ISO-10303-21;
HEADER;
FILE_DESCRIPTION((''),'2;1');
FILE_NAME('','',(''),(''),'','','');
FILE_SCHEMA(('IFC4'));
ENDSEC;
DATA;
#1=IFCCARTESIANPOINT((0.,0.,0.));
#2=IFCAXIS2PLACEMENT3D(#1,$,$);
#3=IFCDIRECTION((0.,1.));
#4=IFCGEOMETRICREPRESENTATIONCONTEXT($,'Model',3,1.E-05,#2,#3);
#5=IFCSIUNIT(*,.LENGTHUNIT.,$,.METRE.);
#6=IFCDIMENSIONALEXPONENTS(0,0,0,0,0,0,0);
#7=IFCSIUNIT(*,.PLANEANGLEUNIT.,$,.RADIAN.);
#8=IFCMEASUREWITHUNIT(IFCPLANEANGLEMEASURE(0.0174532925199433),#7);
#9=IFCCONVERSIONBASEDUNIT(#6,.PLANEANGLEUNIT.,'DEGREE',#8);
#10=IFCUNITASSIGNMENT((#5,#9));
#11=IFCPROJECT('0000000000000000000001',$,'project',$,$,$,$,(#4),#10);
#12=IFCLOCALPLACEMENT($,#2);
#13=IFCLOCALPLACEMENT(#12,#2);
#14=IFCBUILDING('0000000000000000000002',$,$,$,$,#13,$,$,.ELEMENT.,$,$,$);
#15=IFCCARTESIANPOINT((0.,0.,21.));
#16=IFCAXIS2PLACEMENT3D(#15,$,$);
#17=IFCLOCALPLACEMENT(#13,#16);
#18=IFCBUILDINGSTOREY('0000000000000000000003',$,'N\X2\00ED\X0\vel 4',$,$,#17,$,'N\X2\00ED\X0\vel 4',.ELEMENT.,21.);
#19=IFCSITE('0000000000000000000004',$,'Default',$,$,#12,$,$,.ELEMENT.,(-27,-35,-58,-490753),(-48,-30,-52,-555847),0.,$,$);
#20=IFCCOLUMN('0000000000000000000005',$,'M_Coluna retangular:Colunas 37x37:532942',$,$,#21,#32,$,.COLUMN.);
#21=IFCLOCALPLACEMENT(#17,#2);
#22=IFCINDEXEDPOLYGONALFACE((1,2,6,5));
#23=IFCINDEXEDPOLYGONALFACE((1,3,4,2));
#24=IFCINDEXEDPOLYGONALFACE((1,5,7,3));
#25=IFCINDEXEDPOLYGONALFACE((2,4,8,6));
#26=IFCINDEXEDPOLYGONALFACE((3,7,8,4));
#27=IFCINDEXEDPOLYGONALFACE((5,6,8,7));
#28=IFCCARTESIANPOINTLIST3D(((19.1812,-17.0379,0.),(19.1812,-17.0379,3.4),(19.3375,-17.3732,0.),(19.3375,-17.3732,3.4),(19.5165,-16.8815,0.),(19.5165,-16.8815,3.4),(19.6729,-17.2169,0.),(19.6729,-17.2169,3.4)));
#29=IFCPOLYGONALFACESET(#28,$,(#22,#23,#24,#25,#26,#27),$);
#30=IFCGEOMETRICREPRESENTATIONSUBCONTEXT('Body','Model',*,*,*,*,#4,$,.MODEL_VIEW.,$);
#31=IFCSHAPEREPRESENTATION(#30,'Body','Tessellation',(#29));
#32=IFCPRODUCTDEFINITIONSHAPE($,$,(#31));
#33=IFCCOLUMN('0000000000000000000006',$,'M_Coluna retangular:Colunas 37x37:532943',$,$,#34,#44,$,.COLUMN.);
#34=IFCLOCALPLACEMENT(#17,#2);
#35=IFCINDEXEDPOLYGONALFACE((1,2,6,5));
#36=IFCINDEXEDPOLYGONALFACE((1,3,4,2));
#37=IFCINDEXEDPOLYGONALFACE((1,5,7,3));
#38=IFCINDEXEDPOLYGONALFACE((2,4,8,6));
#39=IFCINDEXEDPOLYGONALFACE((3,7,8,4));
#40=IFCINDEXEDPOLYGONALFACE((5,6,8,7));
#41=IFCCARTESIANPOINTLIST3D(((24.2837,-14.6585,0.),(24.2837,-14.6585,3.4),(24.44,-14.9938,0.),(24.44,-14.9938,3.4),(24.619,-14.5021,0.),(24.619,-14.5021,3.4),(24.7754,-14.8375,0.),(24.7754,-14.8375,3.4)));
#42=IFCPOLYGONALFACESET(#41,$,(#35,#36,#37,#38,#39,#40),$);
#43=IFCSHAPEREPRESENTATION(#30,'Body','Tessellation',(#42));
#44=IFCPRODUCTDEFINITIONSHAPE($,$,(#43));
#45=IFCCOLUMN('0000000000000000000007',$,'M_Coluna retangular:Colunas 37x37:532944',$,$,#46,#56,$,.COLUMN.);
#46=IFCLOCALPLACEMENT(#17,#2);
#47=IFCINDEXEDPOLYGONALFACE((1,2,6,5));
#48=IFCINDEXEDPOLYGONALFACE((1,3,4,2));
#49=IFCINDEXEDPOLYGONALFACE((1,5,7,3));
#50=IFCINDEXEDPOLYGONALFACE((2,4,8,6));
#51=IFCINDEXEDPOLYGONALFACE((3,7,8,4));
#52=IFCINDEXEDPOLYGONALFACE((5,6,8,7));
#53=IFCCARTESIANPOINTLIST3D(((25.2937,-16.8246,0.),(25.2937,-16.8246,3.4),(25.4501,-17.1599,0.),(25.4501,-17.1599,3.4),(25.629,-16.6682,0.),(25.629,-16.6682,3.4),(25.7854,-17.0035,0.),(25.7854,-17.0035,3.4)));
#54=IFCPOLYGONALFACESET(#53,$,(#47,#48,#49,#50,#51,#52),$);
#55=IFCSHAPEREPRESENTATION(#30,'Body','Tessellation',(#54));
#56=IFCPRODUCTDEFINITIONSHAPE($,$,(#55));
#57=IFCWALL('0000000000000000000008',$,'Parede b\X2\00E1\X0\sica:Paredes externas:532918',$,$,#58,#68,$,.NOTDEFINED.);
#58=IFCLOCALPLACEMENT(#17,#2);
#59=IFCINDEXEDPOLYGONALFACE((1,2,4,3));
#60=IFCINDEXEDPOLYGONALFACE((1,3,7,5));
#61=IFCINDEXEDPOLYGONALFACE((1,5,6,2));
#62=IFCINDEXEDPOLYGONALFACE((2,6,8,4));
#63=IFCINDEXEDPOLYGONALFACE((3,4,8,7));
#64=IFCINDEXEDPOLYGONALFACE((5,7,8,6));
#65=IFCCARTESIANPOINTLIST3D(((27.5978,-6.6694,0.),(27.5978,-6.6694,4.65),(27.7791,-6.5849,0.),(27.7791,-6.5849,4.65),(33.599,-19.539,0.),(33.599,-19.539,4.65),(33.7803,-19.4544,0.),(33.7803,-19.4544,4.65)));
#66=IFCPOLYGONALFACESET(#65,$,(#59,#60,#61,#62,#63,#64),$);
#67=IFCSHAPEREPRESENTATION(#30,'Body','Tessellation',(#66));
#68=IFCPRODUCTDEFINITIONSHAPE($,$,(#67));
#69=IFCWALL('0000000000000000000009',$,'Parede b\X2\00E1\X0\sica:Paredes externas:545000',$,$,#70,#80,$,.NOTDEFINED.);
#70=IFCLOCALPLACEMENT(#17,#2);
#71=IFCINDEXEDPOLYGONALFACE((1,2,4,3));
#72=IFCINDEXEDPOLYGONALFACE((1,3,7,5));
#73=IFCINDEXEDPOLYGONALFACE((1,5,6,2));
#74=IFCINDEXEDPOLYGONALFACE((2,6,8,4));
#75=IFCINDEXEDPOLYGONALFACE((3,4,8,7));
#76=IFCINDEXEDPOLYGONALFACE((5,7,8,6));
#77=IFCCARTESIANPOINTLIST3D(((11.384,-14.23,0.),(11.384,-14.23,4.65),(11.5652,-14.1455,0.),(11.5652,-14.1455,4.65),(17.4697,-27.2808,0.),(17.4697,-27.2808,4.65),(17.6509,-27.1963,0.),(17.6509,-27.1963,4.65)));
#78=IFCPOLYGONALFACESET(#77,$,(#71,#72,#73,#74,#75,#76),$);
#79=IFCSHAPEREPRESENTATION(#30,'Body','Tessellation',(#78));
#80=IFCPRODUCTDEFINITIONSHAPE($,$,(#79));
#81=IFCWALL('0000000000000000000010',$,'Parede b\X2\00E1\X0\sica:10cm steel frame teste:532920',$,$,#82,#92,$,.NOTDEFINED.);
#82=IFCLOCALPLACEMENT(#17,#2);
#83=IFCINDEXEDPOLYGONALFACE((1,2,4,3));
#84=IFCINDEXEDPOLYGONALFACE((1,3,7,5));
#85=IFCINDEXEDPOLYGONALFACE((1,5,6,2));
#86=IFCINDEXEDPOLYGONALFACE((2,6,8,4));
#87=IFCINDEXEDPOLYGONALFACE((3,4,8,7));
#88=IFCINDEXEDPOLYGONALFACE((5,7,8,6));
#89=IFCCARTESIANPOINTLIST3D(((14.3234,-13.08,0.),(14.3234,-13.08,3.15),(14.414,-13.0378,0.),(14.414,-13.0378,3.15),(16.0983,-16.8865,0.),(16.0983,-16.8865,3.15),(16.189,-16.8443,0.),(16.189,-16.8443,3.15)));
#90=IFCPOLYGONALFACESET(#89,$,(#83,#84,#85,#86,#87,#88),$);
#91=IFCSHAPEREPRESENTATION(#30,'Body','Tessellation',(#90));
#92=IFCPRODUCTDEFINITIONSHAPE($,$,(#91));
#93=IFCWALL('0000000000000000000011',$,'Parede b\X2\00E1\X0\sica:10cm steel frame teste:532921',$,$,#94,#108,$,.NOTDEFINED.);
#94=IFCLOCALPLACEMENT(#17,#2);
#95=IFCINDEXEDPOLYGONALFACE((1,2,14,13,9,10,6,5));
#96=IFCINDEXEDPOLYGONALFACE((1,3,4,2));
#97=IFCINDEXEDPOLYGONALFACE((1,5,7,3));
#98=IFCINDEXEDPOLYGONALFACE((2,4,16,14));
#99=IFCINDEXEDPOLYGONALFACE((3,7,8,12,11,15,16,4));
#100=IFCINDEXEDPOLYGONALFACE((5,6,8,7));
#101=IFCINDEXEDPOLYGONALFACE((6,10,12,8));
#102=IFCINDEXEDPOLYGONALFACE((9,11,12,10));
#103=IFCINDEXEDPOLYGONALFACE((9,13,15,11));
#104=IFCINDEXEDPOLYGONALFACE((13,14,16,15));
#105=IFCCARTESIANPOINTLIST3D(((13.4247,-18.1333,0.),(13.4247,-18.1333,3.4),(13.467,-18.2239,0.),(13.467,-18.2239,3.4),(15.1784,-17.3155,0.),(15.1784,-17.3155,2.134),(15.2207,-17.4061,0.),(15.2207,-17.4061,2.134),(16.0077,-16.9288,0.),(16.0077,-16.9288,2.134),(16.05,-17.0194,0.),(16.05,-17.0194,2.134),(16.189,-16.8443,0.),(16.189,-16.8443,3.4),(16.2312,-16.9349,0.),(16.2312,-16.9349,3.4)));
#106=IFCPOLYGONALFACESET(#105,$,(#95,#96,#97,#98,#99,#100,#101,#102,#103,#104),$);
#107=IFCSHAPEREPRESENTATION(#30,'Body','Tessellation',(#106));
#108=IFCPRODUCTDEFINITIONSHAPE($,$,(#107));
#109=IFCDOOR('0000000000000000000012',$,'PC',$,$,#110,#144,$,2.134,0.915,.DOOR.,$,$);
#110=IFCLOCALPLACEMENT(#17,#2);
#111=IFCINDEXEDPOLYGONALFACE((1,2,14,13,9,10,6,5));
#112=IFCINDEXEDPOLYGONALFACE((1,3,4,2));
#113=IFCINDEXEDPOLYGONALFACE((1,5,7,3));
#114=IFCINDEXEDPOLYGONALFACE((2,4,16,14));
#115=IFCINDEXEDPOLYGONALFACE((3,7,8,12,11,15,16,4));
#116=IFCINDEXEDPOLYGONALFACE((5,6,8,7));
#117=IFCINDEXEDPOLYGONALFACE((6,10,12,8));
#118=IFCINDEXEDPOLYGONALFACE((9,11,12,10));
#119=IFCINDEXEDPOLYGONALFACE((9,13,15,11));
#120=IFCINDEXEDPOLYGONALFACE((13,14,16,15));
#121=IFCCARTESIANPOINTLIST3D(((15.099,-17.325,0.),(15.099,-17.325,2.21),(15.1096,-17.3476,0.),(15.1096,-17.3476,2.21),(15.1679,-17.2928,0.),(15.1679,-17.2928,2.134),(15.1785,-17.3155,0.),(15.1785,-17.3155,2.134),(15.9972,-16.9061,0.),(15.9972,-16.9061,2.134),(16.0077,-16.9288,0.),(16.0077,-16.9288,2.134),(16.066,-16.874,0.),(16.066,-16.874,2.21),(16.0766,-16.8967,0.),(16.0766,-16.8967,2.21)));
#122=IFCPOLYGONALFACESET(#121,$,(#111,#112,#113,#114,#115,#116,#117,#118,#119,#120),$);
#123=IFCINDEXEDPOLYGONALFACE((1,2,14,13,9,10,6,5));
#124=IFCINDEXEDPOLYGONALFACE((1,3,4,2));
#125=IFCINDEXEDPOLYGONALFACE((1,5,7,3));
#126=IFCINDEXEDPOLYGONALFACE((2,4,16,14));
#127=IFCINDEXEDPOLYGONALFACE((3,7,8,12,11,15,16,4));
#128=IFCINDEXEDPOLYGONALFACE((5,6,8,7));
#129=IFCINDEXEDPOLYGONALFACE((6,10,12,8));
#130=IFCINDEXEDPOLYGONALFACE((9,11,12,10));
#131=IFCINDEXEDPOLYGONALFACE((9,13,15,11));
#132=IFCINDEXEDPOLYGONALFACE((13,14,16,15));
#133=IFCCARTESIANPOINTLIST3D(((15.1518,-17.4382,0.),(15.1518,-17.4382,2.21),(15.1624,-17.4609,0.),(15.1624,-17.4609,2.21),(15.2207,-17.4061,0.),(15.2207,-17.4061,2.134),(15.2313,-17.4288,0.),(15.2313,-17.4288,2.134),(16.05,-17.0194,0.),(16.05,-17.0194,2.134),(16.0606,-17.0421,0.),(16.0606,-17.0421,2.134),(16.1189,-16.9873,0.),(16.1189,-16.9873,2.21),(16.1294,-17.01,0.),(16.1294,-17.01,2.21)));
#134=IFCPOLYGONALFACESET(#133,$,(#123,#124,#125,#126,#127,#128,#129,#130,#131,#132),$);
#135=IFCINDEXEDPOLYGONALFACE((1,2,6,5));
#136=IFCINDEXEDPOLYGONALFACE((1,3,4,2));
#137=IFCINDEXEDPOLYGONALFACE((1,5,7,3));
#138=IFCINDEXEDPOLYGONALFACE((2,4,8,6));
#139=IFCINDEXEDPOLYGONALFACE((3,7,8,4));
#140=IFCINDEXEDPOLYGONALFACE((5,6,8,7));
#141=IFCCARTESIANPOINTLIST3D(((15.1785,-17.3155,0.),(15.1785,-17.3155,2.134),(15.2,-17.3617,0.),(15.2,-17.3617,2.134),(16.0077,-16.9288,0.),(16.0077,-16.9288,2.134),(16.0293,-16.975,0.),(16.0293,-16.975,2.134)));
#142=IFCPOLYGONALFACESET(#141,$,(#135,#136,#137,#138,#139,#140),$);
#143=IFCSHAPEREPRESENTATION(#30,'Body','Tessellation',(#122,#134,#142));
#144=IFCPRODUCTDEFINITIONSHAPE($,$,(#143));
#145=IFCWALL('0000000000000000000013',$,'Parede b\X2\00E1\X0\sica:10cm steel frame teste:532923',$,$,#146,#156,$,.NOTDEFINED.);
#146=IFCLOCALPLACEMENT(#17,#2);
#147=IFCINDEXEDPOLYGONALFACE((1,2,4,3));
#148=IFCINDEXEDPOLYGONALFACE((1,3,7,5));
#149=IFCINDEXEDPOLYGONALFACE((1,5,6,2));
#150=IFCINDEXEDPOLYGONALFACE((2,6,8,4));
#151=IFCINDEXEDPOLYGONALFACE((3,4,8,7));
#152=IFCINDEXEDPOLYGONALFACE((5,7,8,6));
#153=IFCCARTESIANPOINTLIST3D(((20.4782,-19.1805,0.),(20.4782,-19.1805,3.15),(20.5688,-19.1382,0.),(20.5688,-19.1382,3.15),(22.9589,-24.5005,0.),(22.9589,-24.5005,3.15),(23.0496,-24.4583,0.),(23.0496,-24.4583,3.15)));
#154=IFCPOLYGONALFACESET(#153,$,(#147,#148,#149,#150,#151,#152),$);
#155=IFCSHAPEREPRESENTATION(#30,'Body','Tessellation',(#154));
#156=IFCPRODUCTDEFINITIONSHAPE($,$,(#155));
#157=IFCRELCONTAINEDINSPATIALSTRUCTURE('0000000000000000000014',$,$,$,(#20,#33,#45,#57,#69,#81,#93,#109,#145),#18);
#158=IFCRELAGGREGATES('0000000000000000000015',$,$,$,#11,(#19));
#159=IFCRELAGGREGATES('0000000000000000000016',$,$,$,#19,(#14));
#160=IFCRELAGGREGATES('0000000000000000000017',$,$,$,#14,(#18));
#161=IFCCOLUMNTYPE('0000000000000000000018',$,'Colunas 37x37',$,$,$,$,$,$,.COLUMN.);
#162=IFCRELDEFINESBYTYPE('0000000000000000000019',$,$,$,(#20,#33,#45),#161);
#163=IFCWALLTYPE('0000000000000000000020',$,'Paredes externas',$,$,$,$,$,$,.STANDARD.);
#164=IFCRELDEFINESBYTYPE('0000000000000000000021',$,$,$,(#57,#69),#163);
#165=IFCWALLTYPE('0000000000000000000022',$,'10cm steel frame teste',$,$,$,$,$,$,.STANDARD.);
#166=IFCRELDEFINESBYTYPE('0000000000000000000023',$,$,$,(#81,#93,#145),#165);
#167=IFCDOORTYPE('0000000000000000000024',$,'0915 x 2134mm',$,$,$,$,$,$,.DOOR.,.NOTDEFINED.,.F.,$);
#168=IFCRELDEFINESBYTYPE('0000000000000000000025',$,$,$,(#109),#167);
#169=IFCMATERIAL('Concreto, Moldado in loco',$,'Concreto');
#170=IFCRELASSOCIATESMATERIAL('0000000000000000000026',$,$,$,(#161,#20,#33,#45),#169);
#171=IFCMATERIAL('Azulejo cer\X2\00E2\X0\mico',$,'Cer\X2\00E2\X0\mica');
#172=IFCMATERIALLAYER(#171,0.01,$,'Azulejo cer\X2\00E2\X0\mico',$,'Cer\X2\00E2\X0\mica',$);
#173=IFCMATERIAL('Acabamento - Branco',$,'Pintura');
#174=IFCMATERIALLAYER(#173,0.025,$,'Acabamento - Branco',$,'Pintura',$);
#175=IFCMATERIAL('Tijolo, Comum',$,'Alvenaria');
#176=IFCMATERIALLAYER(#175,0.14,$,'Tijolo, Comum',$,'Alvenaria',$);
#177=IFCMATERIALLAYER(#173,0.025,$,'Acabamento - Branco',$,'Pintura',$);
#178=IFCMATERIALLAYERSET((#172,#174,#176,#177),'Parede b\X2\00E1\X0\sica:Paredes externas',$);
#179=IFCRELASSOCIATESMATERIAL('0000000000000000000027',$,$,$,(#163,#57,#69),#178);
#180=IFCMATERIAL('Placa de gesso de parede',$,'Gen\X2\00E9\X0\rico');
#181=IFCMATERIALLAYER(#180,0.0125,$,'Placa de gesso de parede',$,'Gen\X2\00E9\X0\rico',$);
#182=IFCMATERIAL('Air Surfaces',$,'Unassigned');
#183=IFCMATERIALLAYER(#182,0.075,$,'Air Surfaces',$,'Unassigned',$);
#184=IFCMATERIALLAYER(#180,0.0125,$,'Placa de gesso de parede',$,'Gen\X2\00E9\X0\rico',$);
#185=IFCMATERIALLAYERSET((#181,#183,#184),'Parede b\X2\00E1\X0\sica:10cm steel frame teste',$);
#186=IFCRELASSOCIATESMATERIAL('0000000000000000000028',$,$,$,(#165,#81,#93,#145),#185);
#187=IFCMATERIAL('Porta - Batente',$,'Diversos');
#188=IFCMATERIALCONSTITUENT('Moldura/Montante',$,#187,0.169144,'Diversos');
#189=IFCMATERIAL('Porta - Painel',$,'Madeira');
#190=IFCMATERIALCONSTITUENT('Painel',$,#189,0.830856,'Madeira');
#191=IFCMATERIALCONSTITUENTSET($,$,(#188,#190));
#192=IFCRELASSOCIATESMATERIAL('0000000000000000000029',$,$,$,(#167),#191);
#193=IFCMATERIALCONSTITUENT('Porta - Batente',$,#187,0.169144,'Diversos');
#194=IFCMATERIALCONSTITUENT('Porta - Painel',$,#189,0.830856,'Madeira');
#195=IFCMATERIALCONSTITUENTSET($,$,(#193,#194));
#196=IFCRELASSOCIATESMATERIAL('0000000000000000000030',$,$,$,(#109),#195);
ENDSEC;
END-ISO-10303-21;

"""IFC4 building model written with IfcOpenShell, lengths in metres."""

from ifc_helpers import new_model, entity, si_unit, converted_unit, direction, frame, frame_2d, origin, origin_2d_with_axis, place, context, subcontext, project, spatial, polyline, rectangle, outline, extrude, source, transform, mapped, material, layer, layer_set, layer_usage, constituent, constituent_set, material_profile, profile_set, profile_usage, type_object, type_shapes, element, fill, save


model = new_model("IFC4")

# Units and contexts
model_context = context("Model", 3, precision=1e-05, world=origin(), true_north=direction((0.0, 1.0)))
body_context = subcontext(model_context, "Body", "Model", "MODEL_VIEW")
ifc_project = project(units=[si_unit("LENGTHUNIT", "METRE"), converted_unit("PLANEANGLEUNIT", "DEGREE", entity("IfcPlaneAngleMeasure", 0.0174532925199433), si_unit("PLANEANGLEUNIT", "RADIAN"), dimensions=[0, 0, 0, 0, 0, 0, 0])], contexts=[model_context])

# Site, building, storey
site_placement = place(None, origin())
site = spatial("IfcSite", under=ifc_project, at=site_placement, Name="Default", CompositionType="ELEMENT", RefLatitude=(-27, -35, -58, -490753), RefLongitude=(-48, -30, -52, -555847), RefElevation=0.0)
building_placement = place(site_placement, origin())
building = spatial("IfcBuilding", under=site, at=building_placement, CompositionType="ELEMENT")
storey_placement = place(building_placement, frame((0.0, 0.0, 21.0)))
storey = spatial("IfcBuildingStorey", under=building, at=storey_placement, Name="Nível 4", LongName="Nível 4", CompositionType="ELEMENT", Elevation=21.0)

# Columns
ifc_material_1 = material(Name="Concreto, Moldado in loco", Category="Concreto")
ifc_material_profile = material_profile(ifc_material_1, rectangle(XDim=0.37, YDim=0.37, at=origin_2d_with_axis()), Name="Colunas 37x37")
ifc_profile_set = profile_set([ifc_material_profile], Name="Colunas 37x37")
ifc_profile_usage = profile_usage(ifc_profile_set)
column_type = type_object("IfcColumnType", Name="Colunas 37x37", PredefinedType="COLUMN", material=ifc_profile_set)
shared_shape_1 = source(origin(), body_context, "Body", "SweptSolid", [
    extrude(rectangle(XDim=0.37, YDim=0.37, at=origin_2d_with_axis()), frame((0.0, 0.0, 21.0), z_axis=(0.0, 0.0, 1.0), x_axis=(-1.0, 0.0, 0.0)), (0.0, 0.0, 1.0), 3.4),
])
type_shapes(column_type, [shared_shape_1])
for number, where, z_axis, x_axis, name in (
    (1, (19.427, -17.1274, -21.0), (0.0, 0.0, 1.0), (0.906308, 0.422618, 0.0), "M_Coluna retangular:Colunas 37x37:532942"),
    (2, (24.5295, -14.748, -21.0), (0.0, 0.0, 1.0), (0.906308, 0.422618, 0.0), "M_Coluna retangular:Colunas 37x37:532943"),
    (3, (25.5396, -16.9141, -21.0), (0.0, 0.0, 1.0), (0.906308, 0.422618, 0.0), "M_Coluna retangular:Colunas 37x37:532944"),
):
    element("IfcColumn", number, at=place(storey_placement, frame(where, z_axis=z_axis, x_axis=x_axis)), inside=storey, type_object=column_type, material=ifc_profile_usage, Name=name, PredefinedType="COLUMN", context=body_context, shape_type="MappedRepresentation", body=[
        mapped(shared_shape_1, transform((0.0, 0.0, 0.0), scale=1.0)),
    ])

# Walls
ifc_material_2 = material(Name="Azulejo cerâmico", Category="Cerâmica")
ifc_layer_1 = layer(ifc_material_2, 0.01, Name="Azulejo cerâmico", Category="Cerâmica")
ifc_material_3 = material(Name="Acabamento - Branco", Category="Pintura")
ifc_layer_2 = layer(ifc_material_3, 0.025, Name="Acabamento - Branco", Category="Pintura")
ifc_material_4 = material(Name="Tijolo, Comum", Category="Alvenaria")
ifc_layer_3 = layer(ifc_material_4, 0.14, Name="Tijolo, Comum", Category="Alvenaria")
ifc_layer_4 = layer(ifc_material_3, 0.025, Name="Acabamento - Branco", Category="Pintura")
ifc_layer_set_1 = layer_set([ifc_layer_1, ifc_layer_2, ifc_layer_3, ifc_layer_4], Name="Parede básica:Paredes externas")
ifc_layer_usage_1 = layer_usage(ifc_layer_set_1, "AXIS2", "POSITIVE", -0.1)
wall_type_1 = type_object("IfcWallType", Name="Paredes externas", PredefinedType="STANDARD", material=ifc_layer_set_1)
wall_1_placement = place(storey_placement, frame((33.6896, -19.4967, 0.0), z_axis=(0.0, 0.0, 1.0), x_axis=(-0.422618, 0.906308, 0.0)))
element("IfcWall", 4, at=wall_1_placement, inside=storey, type_object=wall_type_1, material=ifc_layer_usage_1, Name="Parede básica:Paredes externas:532918", PredefinedType="NOTDEFINED", context=body_context, shape_type="SweptSolid", body=[
    extrude(rectangle(XDim=14.2, YDim=0.2, at=frame_2d((7.1, 0.0), x_axis=(-1.0, 0.0))), origin(), (0.0, 0.0, 1.0), 4.65),
])
ifc_layer_usage_2 = layer_usage(ifc_layer_set_1, "AXIS2", "POSITIVE", -0.1)
wall_2_placement = place(storey_placement, frame((11.4746, -14.1877, 0.0), z_axis=(0.0, 0.0, 1.0), x_axis=(0.422618, -0.906308, 0.0)))
element("IfcWall", 5, at=wall_2_placement, inside=storey, type_object=wall_type_1, material=ifc_layer_usage_2, Name="Parede básica:Paredes externas:545000", PredefinedType="NOTDEFINED", context=body_context, shape_type="SweptSolid", body=[
    extrude(rectangle(XDim=14.4, YDim=0.2, at=frame_2d((7.2, 0.0), x_axis=(-1.0, 0.0))), origin(), (0.0, 0.0, 1.0), 4.65),
])
ifc_material_5 = material(Name="Placa de gesso de parede", Category="Genérico")
ifc_layer_5 = layer(ifc_material_5, 0.0125, Name="Placa de gesso de parede", Category="Genérico")
ifc_material_6 = material(Name="Air Surfaces", Category="Unassigned")
ifc_layer_6 = layer(ifc_material_6, 0.075, Name="Air Surfaces", Category="Unassigned")
ifc_layer_7 = layer(ifc_material_5, 0.0125, Name="Placa de gesso de parede", Category="Genérico")
ifc_layer_set_2 = layer_set([ifc_layer_5, ifc_layer_6, ifc_layer_7], Name="Parede básica:10cm steel frame teste")
ifc_layer_usage_3 = layer_usage(ifc_layer_set_2, "AXIS2", "NEGATIVE", 0.05)
wall_type_2 = type_object("IfcWallType", Name="10cm steel frame teste", PredefinedType="STANDARD", material=ifc_layer_set_2)
wall_3_placement = place(storey_placement, frame((14.3687, -13.0589, 0.0), z_axis=(0.0, 0.0, 1.0), x_axis=(0.422618, -0.906308, 0.0)))
element("IfcWall", 6, at=wall_3_placement, inside=storey, type_object=wall_type_2, material=ifc_layer_usage_3, Name="Parede básica:10cm steel frame teste:532920", PredefinedType="NOTDEFINED", context=body_context, shape_type="SweptSolid", body=[
    extrude(rectangle(XDim=4.2, YDim=0.1, at=frame_2d((2.1, 0.0), x_axis=(-1.0, 0.0))), origin(), (0.0, 0.0, 1.0), 3.15),
])

# Wall, opening, door
ifc_layer_usage_4 = layer_usage(ifc_layer_set_2, "AXIS2", "NEGATIVE", 0.05)
wall_4_placement = place(storey_placement, frame((16.2101, -16.8896, 0.0), z_axis=(0.0, 0.0, 1.0), x_axis=(-0.906308, -0.422618, 0.0)))
wall_4 = element("IfcWall", 7, at=wall_4_placement, inside=storey, type_object=wall_type_2, material=ifc_layer_usage_4, Name="Parede básica:10cm steel frame teste:532921", PredefinedType="NOTDEFINED", context=body_context, shape_type="SweptSolid", body=[
    extrude(rectangle(XDim=3.05, YDim=0.1, at=frame_2d((1.525, 0.0), x_axis=(1.0, 0.0))), origin(), (0.0, 0.0, 1.0), 3.4),
])
opening_1_placement = place(wall_4_placement, frame((1.115, 0.05, 0.0)))
opening_1 = element("IfcOpeningElement", 8, at=opening_1_placement, cuts=wall_4, PredefinedType="OPENING", context=body_context, shape_type="SweptSolid", body=[
    extrude(rectangle(XDim=0.915, YDim=2.134, at=frame_2d((1.067, 0.4575), x_axis=(0.0, 1.0))), frame((0.0, 0.0, 0.0), z_axis=(0.0, -1.0, 0.0), x_axis=(0.0, 0.0, 1.0)), (0.0, 0.0, 1.0), 0.1),
])
ifc_material_7 = material(Name="Porta - Batente", Category="Diversos")
ifc_constituent_1 = constituent(ifc_material_7, Name="Porta - Batente", Category="Diversos", fraction=0.169144)
ifc_material_8 = material(Name="Porta - Painel", Category="Madeira")
ifc_constituent_2 = constituent(ifc_material_8, Name="Porta - Painel", Category="Madeira", fraction=0.830856)
ifc_constituent_set_1 = constituent_set(constituents=[ifc_constituent_1, ifc_constituent_2])
ifc_constituent_3 = constituent(ifc_material_7, Name="Moldura/Montante", Category="Diversos", fraction=0.169144)
ifc_constituent_4 = constituent(ifc_material_8, Name="Painel", Category="Madeira", fraction=0.830856)
ifc_constituent_set_2 = constituent_set(constituents=[ifc_constituent_3, ifc_constituent_4])
door_type_1 = type_object("IfcDoorType", Name="0915 x 2134mm", OperationType="NOTDEFINED", ParameterTakesPrecedence=False, PredefinedType="DOOR", material=ifc_constituent_set_2)
shared_shape_2 = source(origin(), body_context, "Body", "SweptSolid", [
    extrude(outline(polyline([(-0.5335, -1.124), (0.5335, -1.124), (0.5335, 1.086), (0.4575, 1.086), (0.4575, -1.048), (-0.4575, -1.048), (-0.4575, 1.086), (-0.5335, 1.086), (-0.5335, -1.124)])), frame((0.4575, 0.1, 1.086), z_axis=(0.0, 1.0, 0.0), x_axis=(1.0, 0.0, 0.0)), (0.0, 0.0, 1.0), 0.025),
    extrude(outline(polyline([(-1.124, -0.5335), (1.086, -0.5335), (1.086, -0.4575), (-1.048, -0.4575), (-1.048, 0.4575), (1.086, 0.4575), (1.086, 0.5335), (-1.124, 0.5335), (-1.124, -0.5335)])), frame((0.4575, -0.025, 1.086), z_axis=(0.0, 1.0, 0.0), x_axis=(0.0, 0.0, -1.0)), (0.0, 0.0, 1.0), 0.025),
    extrude(rectangle(XDim=0.051, YDim=0.915, at=origin_2d_with_axis()), frame((0.4575, 0.0745, 0.0), z_axis=(0.0, 0.0, 1.0), x_axis=(0.0, 1.0, 0.0)), (0.0, 0.0, 1.0), 2.134),
])
type_shapes(door_type_1, [shared_shape_2])
door_1_placement = place(opening_1_placement, frame((0.0, 0.0, 0.0), z_axis=(0.0, 0.0, 1.0), x_axis=(-1.0, 0.0, 0.0)))
door_1 = element("IfcDoor", 9, at=door_1_placement, inside=storey, type_object=door_type_1, material=ifc_constituent_set_1, Name="PC", OverallHeight=2.134, OverallWidth=0.915, PredefinedType="DOOR", context=body_context, shape_type="MappedRepresentation", body=[
    mapped(shared_shape_2, transform((0.0, 0.0, 0.0), scale=1.0)),
])
fill(opening_1, door_1)

# Wall
ifc_layer_usage_5 = layer_usage(ifc_layer_set_2, "AXIS2", "NEGATIVE", 0.05)
wall_5_placement = place(storey_placement, frame((20.5235, -19.1594, 0.0), z_axis=(0.0, 0.0, 1.0), x_axis=(0.422618, -0.906308, 0.0)))
element("IfcWall", 10, at=wall_5_placement, inside=storey, type_object=wall_type_2, material=ifc_layer_usage_5, Name="Parede básica:10cm steel frame teste:532923", PredefinedType="NOTDEFINED", context=body_context, shape_type="SweptSolid", body=[
    extrude(rectangle(XDim=5.87, YDim=0.1, at=frame_2d((2.935, 0.0), x_axis=(-1.0, 0.0))), origin(), (0.0, 0.0, 1.0), 3.15),
])

save(model, "model.ifc")
